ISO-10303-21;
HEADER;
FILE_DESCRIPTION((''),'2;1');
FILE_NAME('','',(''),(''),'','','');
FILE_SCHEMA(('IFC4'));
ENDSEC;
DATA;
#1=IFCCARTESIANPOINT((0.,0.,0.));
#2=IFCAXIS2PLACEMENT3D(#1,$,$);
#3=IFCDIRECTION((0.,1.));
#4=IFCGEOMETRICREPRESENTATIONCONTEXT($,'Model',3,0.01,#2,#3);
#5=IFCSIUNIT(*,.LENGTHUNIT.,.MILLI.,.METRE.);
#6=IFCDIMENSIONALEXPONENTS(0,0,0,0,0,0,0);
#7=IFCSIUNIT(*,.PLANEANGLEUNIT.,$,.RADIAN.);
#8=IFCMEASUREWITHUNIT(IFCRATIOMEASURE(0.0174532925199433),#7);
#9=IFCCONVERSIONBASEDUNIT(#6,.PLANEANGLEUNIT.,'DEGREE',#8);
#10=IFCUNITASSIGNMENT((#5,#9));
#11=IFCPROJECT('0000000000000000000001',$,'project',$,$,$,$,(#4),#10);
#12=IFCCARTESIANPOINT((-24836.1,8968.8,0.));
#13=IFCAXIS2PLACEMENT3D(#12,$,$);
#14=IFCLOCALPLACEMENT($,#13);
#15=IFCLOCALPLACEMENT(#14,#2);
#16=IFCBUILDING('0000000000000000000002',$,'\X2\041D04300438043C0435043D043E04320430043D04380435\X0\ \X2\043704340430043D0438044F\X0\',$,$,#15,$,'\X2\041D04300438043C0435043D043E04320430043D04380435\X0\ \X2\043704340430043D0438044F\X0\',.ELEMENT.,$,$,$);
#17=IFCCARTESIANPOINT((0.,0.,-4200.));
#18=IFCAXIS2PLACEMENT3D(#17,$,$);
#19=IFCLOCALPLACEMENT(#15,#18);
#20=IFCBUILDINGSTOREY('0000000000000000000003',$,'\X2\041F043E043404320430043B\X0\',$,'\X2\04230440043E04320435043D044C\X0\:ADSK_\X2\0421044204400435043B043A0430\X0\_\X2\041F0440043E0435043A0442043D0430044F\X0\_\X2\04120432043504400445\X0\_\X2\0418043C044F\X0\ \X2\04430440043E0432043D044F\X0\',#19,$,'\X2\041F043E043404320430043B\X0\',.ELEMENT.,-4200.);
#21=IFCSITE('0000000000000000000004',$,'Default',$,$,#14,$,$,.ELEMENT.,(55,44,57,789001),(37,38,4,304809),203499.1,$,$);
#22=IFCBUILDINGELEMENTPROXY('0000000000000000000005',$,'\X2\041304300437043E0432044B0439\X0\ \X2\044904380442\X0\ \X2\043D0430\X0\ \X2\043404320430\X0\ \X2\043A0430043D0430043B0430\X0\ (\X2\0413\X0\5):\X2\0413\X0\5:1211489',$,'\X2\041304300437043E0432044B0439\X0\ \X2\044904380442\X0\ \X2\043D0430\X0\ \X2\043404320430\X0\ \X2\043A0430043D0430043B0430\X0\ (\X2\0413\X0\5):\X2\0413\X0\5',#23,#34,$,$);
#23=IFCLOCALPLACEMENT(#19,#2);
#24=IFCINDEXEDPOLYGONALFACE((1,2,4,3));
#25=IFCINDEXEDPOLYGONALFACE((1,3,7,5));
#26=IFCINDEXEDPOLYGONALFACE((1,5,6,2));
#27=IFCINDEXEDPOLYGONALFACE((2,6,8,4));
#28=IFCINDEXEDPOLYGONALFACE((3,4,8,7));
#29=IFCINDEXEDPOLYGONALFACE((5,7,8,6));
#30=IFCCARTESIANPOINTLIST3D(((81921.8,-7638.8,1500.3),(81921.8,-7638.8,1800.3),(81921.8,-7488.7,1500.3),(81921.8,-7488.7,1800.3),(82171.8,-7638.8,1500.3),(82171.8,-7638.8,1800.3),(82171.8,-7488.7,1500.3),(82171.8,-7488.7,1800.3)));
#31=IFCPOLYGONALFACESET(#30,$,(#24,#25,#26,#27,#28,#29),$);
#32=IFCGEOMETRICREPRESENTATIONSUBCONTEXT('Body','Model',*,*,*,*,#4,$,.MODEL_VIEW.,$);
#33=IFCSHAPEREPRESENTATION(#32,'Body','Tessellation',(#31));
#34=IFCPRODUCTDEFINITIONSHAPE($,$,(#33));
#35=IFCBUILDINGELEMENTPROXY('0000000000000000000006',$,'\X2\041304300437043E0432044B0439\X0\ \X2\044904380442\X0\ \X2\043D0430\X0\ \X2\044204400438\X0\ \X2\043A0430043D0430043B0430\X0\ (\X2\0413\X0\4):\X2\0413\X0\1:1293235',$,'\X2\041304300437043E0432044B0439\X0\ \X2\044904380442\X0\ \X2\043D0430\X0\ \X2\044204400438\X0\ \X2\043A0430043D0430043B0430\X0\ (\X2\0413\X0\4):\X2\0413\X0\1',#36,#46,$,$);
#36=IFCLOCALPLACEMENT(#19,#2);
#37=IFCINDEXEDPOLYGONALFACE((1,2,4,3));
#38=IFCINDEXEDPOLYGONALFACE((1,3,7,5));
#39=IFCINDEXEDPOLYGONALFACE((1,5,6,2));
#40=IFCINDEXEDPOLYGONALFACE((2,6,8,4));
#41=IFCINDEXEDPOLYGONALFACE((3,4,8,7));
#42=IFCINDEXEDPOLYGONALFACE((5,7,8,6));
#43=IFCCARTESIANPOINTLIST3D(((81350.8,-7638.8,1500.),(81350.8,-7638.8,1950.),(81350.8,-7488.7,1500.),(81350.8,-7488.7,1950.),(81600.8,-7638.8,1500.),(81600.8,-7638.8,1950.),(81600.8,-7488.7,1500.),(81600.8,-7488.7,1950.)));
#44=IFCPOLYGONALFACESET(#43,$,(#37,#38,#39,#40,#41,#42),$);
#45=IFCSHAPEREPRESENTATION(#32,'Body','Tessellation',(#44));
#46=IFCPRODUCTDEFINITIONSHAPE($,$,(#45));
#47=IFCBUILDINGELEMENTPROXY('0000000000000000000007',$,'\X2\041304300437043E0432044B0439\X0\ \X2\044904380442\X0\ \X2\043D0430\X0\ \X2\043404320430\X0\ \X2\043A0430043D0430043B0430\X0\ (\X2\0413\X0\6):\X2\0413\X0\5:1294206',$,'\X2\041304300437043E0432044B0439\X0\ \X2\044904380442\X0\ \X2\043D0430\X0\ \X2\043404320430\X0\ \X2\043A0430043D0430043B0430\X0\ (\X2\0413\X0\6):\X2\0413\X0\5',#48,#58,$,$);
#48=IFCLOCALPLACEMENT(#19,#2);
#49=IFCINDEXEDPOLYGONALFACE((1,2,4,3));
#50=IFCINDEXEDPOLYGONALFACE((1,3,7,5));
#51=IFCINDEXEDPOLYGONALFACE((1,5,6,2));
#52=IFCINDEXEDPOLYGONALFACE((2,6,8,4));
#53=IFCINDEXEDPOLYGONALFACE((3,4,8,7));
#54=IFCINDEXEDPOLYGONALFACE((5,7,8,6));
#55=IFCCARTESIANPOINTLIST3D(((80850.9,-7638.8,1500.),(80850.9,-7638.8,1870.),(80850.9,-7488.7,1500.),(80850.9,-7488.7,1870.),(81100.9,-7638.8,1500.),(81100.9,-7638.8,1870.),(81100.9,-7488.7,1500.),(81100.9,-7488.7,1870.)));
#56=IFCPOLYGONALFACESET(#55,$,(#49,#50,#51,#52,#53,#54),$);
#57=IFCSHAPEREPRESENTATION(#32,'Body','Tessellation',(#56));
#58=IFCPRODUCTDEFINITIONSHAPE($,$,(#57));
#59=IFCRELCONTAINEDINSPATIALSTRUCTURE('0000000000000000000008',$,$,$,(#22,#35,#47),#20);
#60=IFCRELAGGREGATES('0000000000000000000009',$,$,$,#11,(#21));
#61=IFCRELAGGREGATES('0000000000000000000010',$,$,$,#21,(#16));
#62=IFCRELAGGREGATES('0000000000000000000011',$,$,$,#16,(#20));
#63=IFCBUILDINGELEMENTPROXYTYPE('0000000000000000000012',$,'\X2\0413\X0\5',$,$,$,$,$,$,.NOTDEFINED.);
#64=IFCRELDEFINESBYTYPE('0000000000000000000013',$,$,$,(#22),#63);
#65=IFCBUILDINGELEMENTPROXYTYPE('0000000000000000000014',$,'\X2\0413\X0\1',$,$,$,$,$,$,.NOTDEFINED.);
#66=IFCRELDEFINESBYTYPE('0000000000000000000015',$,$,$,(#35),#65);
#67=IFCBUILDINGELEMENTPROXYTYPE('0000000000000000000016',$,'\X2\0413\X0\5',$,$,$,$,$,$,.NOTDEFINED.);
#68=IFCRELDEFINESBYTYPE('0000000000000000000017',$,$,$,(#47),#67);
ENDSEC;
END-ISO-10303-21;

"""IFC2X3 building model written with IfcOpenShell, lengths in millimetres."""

from ifc_helpers import new_model, entity, si_unit, converted_unit, direction, frame, origin, origin_2d_with_axis, place, context, subcontext, project, spatial, rectangle, extrude, type_object, element, save


model = new_model("IFC2X3")

# Units and contexts
model_context = context("Model", 3, precision=0.01, world=origin(), true_north=direction((0.0, 1.0)))
body_context = subcontext(model_context, "Body", "Model", "MODEL_VIEW")
ifc_project = project(units=[si_unit("LENGTHUNIT", "METRE", prefix="MILLI"), converted_unit("PLANEANGLEUNIT", "DEGREE", entity("IfcRatioMeasure", 0.0174532925199433), si_unit("PLANEANGLEUNIT", "RADIAN"), dimensions=[0, 0, 0, 0, 0, 0, 0])], contexts=[model_context])

# Site, building, storey
site_placement = place(None, frame((-24836.1, 8968.8, 0.0)))
site = spatial("IfcSite", under=ifc_project, at=site_placement, Name="Default", CompositionType="ELEMENT", RefLatitude=(55, 44, 57, 789001), RefLongitude=(37, 38, 4, 304809), RefElevation=203499.1)
building_placement = place(site_placement, origin())
building = spatial("IfcBuilding", under=site, at=building_placement, Name="Наименование здания", LongName="Наименование здания", CompositionType="ELEMENT")
storey_placement = place(building_placement, frame((0.0, 0.0, -4200.0)))
storey = spatial("IfcBuildingStorey", under=building, at=storey_placement, Name="Подвал", ObjectType="Уровень:ADSK_Стрелка_Проектная_Вверх_Имя уровня", LongName="Подвал", CompositionType="ELEMENT", Elevation=-4200.0)

# Building element proxies
building_element_proxy_type_1 = type_object("IfcBuildingElementProxyType", Name="Г5", PredefinedType="NOTDEFINED")
proxy_1_placement = place(storey_placement, frame((81921.8, -7638.8, 1500.3)))
element("IfcBuildingElementProxy", 1, at=proxy_1_placement, inside=storey, type_object=building_element_proxy_type_1, Name="Газовый щит на два канала (Г5):Г5:1211489", ObjectType="Газовый щит на два канала (Г5):Г5", context=body_context, shape_type="SweptSolid", body=[
    extrude(rectangle(XDim=150.0, YDim=250.0, at=origin_2d_with_axis()), frame((125.0, 75.0, 0.0), z_axis=(0.0, 0.0, 1.0), x_axis=(0.0, -1.0, 0.0)), (0.0, 0.0, 1.0), 300.0),
])
building_element_proxy_type_2 = type_object("IfcBuildingElementProxyType", Name="Г1", PredefinedType="NOTDEFINED")
proxy_2_placement = place(storey_placement, frame((81350.8, -7638.8, 1500.0)))
element("IfcBuildingElementProxy", 2, at=proxy_2_placement, inside=storey, type_object=building_element_proxy_type_2, Name="Газовый щит на три канала (Г4):Г1:1293235", ObjectType="Газовый щит на три канала (Г4):Г1", context=body_context, shape_type="SweptSolid", body=[
    extrude(rectangle(XDim=150.0, YDim=250.0, at=origin_2d_with_axis()), frame((125.0, 75.0, 0.0), z_axis=(0.0, 0.0, 1.0), x_axis=(0.0, -1.0, 0.0)), (0.0, 0.0, 1.0), 450.0),
])
building_element_proxy_type_3 = type_object("IfcBuildingElementProxyType", Name="Г5", PredefinedType="NOTDEFINED")
proxy_3_placement = place(storey_placement, frame((80850.9, -7638.8, 1500.0)))
element("IfcBuildingElementProxy", 3, at=proxy_3_placement, inside=storey, type_object=building_element_proxy_type_3, Name="Газовый щит на два канала (Г6):Г5:1294206", ObjectType="Газовый щит на два канала (Г6):Г5", context=body_context, shape_type="SweptSolid", body=[
    extrude(rectangle(XDim=150.0, YDim=250.0, at=origin_2d_with_axis()), frame((125.0, 75.0, 0.0), z_axis=(0.0, 0.0, 1.0), x_axis=(0.0, -1.0, 0.0)), (0.0, 0.0, 1.0), 370.0),
])

save(model, "model.ifc")
